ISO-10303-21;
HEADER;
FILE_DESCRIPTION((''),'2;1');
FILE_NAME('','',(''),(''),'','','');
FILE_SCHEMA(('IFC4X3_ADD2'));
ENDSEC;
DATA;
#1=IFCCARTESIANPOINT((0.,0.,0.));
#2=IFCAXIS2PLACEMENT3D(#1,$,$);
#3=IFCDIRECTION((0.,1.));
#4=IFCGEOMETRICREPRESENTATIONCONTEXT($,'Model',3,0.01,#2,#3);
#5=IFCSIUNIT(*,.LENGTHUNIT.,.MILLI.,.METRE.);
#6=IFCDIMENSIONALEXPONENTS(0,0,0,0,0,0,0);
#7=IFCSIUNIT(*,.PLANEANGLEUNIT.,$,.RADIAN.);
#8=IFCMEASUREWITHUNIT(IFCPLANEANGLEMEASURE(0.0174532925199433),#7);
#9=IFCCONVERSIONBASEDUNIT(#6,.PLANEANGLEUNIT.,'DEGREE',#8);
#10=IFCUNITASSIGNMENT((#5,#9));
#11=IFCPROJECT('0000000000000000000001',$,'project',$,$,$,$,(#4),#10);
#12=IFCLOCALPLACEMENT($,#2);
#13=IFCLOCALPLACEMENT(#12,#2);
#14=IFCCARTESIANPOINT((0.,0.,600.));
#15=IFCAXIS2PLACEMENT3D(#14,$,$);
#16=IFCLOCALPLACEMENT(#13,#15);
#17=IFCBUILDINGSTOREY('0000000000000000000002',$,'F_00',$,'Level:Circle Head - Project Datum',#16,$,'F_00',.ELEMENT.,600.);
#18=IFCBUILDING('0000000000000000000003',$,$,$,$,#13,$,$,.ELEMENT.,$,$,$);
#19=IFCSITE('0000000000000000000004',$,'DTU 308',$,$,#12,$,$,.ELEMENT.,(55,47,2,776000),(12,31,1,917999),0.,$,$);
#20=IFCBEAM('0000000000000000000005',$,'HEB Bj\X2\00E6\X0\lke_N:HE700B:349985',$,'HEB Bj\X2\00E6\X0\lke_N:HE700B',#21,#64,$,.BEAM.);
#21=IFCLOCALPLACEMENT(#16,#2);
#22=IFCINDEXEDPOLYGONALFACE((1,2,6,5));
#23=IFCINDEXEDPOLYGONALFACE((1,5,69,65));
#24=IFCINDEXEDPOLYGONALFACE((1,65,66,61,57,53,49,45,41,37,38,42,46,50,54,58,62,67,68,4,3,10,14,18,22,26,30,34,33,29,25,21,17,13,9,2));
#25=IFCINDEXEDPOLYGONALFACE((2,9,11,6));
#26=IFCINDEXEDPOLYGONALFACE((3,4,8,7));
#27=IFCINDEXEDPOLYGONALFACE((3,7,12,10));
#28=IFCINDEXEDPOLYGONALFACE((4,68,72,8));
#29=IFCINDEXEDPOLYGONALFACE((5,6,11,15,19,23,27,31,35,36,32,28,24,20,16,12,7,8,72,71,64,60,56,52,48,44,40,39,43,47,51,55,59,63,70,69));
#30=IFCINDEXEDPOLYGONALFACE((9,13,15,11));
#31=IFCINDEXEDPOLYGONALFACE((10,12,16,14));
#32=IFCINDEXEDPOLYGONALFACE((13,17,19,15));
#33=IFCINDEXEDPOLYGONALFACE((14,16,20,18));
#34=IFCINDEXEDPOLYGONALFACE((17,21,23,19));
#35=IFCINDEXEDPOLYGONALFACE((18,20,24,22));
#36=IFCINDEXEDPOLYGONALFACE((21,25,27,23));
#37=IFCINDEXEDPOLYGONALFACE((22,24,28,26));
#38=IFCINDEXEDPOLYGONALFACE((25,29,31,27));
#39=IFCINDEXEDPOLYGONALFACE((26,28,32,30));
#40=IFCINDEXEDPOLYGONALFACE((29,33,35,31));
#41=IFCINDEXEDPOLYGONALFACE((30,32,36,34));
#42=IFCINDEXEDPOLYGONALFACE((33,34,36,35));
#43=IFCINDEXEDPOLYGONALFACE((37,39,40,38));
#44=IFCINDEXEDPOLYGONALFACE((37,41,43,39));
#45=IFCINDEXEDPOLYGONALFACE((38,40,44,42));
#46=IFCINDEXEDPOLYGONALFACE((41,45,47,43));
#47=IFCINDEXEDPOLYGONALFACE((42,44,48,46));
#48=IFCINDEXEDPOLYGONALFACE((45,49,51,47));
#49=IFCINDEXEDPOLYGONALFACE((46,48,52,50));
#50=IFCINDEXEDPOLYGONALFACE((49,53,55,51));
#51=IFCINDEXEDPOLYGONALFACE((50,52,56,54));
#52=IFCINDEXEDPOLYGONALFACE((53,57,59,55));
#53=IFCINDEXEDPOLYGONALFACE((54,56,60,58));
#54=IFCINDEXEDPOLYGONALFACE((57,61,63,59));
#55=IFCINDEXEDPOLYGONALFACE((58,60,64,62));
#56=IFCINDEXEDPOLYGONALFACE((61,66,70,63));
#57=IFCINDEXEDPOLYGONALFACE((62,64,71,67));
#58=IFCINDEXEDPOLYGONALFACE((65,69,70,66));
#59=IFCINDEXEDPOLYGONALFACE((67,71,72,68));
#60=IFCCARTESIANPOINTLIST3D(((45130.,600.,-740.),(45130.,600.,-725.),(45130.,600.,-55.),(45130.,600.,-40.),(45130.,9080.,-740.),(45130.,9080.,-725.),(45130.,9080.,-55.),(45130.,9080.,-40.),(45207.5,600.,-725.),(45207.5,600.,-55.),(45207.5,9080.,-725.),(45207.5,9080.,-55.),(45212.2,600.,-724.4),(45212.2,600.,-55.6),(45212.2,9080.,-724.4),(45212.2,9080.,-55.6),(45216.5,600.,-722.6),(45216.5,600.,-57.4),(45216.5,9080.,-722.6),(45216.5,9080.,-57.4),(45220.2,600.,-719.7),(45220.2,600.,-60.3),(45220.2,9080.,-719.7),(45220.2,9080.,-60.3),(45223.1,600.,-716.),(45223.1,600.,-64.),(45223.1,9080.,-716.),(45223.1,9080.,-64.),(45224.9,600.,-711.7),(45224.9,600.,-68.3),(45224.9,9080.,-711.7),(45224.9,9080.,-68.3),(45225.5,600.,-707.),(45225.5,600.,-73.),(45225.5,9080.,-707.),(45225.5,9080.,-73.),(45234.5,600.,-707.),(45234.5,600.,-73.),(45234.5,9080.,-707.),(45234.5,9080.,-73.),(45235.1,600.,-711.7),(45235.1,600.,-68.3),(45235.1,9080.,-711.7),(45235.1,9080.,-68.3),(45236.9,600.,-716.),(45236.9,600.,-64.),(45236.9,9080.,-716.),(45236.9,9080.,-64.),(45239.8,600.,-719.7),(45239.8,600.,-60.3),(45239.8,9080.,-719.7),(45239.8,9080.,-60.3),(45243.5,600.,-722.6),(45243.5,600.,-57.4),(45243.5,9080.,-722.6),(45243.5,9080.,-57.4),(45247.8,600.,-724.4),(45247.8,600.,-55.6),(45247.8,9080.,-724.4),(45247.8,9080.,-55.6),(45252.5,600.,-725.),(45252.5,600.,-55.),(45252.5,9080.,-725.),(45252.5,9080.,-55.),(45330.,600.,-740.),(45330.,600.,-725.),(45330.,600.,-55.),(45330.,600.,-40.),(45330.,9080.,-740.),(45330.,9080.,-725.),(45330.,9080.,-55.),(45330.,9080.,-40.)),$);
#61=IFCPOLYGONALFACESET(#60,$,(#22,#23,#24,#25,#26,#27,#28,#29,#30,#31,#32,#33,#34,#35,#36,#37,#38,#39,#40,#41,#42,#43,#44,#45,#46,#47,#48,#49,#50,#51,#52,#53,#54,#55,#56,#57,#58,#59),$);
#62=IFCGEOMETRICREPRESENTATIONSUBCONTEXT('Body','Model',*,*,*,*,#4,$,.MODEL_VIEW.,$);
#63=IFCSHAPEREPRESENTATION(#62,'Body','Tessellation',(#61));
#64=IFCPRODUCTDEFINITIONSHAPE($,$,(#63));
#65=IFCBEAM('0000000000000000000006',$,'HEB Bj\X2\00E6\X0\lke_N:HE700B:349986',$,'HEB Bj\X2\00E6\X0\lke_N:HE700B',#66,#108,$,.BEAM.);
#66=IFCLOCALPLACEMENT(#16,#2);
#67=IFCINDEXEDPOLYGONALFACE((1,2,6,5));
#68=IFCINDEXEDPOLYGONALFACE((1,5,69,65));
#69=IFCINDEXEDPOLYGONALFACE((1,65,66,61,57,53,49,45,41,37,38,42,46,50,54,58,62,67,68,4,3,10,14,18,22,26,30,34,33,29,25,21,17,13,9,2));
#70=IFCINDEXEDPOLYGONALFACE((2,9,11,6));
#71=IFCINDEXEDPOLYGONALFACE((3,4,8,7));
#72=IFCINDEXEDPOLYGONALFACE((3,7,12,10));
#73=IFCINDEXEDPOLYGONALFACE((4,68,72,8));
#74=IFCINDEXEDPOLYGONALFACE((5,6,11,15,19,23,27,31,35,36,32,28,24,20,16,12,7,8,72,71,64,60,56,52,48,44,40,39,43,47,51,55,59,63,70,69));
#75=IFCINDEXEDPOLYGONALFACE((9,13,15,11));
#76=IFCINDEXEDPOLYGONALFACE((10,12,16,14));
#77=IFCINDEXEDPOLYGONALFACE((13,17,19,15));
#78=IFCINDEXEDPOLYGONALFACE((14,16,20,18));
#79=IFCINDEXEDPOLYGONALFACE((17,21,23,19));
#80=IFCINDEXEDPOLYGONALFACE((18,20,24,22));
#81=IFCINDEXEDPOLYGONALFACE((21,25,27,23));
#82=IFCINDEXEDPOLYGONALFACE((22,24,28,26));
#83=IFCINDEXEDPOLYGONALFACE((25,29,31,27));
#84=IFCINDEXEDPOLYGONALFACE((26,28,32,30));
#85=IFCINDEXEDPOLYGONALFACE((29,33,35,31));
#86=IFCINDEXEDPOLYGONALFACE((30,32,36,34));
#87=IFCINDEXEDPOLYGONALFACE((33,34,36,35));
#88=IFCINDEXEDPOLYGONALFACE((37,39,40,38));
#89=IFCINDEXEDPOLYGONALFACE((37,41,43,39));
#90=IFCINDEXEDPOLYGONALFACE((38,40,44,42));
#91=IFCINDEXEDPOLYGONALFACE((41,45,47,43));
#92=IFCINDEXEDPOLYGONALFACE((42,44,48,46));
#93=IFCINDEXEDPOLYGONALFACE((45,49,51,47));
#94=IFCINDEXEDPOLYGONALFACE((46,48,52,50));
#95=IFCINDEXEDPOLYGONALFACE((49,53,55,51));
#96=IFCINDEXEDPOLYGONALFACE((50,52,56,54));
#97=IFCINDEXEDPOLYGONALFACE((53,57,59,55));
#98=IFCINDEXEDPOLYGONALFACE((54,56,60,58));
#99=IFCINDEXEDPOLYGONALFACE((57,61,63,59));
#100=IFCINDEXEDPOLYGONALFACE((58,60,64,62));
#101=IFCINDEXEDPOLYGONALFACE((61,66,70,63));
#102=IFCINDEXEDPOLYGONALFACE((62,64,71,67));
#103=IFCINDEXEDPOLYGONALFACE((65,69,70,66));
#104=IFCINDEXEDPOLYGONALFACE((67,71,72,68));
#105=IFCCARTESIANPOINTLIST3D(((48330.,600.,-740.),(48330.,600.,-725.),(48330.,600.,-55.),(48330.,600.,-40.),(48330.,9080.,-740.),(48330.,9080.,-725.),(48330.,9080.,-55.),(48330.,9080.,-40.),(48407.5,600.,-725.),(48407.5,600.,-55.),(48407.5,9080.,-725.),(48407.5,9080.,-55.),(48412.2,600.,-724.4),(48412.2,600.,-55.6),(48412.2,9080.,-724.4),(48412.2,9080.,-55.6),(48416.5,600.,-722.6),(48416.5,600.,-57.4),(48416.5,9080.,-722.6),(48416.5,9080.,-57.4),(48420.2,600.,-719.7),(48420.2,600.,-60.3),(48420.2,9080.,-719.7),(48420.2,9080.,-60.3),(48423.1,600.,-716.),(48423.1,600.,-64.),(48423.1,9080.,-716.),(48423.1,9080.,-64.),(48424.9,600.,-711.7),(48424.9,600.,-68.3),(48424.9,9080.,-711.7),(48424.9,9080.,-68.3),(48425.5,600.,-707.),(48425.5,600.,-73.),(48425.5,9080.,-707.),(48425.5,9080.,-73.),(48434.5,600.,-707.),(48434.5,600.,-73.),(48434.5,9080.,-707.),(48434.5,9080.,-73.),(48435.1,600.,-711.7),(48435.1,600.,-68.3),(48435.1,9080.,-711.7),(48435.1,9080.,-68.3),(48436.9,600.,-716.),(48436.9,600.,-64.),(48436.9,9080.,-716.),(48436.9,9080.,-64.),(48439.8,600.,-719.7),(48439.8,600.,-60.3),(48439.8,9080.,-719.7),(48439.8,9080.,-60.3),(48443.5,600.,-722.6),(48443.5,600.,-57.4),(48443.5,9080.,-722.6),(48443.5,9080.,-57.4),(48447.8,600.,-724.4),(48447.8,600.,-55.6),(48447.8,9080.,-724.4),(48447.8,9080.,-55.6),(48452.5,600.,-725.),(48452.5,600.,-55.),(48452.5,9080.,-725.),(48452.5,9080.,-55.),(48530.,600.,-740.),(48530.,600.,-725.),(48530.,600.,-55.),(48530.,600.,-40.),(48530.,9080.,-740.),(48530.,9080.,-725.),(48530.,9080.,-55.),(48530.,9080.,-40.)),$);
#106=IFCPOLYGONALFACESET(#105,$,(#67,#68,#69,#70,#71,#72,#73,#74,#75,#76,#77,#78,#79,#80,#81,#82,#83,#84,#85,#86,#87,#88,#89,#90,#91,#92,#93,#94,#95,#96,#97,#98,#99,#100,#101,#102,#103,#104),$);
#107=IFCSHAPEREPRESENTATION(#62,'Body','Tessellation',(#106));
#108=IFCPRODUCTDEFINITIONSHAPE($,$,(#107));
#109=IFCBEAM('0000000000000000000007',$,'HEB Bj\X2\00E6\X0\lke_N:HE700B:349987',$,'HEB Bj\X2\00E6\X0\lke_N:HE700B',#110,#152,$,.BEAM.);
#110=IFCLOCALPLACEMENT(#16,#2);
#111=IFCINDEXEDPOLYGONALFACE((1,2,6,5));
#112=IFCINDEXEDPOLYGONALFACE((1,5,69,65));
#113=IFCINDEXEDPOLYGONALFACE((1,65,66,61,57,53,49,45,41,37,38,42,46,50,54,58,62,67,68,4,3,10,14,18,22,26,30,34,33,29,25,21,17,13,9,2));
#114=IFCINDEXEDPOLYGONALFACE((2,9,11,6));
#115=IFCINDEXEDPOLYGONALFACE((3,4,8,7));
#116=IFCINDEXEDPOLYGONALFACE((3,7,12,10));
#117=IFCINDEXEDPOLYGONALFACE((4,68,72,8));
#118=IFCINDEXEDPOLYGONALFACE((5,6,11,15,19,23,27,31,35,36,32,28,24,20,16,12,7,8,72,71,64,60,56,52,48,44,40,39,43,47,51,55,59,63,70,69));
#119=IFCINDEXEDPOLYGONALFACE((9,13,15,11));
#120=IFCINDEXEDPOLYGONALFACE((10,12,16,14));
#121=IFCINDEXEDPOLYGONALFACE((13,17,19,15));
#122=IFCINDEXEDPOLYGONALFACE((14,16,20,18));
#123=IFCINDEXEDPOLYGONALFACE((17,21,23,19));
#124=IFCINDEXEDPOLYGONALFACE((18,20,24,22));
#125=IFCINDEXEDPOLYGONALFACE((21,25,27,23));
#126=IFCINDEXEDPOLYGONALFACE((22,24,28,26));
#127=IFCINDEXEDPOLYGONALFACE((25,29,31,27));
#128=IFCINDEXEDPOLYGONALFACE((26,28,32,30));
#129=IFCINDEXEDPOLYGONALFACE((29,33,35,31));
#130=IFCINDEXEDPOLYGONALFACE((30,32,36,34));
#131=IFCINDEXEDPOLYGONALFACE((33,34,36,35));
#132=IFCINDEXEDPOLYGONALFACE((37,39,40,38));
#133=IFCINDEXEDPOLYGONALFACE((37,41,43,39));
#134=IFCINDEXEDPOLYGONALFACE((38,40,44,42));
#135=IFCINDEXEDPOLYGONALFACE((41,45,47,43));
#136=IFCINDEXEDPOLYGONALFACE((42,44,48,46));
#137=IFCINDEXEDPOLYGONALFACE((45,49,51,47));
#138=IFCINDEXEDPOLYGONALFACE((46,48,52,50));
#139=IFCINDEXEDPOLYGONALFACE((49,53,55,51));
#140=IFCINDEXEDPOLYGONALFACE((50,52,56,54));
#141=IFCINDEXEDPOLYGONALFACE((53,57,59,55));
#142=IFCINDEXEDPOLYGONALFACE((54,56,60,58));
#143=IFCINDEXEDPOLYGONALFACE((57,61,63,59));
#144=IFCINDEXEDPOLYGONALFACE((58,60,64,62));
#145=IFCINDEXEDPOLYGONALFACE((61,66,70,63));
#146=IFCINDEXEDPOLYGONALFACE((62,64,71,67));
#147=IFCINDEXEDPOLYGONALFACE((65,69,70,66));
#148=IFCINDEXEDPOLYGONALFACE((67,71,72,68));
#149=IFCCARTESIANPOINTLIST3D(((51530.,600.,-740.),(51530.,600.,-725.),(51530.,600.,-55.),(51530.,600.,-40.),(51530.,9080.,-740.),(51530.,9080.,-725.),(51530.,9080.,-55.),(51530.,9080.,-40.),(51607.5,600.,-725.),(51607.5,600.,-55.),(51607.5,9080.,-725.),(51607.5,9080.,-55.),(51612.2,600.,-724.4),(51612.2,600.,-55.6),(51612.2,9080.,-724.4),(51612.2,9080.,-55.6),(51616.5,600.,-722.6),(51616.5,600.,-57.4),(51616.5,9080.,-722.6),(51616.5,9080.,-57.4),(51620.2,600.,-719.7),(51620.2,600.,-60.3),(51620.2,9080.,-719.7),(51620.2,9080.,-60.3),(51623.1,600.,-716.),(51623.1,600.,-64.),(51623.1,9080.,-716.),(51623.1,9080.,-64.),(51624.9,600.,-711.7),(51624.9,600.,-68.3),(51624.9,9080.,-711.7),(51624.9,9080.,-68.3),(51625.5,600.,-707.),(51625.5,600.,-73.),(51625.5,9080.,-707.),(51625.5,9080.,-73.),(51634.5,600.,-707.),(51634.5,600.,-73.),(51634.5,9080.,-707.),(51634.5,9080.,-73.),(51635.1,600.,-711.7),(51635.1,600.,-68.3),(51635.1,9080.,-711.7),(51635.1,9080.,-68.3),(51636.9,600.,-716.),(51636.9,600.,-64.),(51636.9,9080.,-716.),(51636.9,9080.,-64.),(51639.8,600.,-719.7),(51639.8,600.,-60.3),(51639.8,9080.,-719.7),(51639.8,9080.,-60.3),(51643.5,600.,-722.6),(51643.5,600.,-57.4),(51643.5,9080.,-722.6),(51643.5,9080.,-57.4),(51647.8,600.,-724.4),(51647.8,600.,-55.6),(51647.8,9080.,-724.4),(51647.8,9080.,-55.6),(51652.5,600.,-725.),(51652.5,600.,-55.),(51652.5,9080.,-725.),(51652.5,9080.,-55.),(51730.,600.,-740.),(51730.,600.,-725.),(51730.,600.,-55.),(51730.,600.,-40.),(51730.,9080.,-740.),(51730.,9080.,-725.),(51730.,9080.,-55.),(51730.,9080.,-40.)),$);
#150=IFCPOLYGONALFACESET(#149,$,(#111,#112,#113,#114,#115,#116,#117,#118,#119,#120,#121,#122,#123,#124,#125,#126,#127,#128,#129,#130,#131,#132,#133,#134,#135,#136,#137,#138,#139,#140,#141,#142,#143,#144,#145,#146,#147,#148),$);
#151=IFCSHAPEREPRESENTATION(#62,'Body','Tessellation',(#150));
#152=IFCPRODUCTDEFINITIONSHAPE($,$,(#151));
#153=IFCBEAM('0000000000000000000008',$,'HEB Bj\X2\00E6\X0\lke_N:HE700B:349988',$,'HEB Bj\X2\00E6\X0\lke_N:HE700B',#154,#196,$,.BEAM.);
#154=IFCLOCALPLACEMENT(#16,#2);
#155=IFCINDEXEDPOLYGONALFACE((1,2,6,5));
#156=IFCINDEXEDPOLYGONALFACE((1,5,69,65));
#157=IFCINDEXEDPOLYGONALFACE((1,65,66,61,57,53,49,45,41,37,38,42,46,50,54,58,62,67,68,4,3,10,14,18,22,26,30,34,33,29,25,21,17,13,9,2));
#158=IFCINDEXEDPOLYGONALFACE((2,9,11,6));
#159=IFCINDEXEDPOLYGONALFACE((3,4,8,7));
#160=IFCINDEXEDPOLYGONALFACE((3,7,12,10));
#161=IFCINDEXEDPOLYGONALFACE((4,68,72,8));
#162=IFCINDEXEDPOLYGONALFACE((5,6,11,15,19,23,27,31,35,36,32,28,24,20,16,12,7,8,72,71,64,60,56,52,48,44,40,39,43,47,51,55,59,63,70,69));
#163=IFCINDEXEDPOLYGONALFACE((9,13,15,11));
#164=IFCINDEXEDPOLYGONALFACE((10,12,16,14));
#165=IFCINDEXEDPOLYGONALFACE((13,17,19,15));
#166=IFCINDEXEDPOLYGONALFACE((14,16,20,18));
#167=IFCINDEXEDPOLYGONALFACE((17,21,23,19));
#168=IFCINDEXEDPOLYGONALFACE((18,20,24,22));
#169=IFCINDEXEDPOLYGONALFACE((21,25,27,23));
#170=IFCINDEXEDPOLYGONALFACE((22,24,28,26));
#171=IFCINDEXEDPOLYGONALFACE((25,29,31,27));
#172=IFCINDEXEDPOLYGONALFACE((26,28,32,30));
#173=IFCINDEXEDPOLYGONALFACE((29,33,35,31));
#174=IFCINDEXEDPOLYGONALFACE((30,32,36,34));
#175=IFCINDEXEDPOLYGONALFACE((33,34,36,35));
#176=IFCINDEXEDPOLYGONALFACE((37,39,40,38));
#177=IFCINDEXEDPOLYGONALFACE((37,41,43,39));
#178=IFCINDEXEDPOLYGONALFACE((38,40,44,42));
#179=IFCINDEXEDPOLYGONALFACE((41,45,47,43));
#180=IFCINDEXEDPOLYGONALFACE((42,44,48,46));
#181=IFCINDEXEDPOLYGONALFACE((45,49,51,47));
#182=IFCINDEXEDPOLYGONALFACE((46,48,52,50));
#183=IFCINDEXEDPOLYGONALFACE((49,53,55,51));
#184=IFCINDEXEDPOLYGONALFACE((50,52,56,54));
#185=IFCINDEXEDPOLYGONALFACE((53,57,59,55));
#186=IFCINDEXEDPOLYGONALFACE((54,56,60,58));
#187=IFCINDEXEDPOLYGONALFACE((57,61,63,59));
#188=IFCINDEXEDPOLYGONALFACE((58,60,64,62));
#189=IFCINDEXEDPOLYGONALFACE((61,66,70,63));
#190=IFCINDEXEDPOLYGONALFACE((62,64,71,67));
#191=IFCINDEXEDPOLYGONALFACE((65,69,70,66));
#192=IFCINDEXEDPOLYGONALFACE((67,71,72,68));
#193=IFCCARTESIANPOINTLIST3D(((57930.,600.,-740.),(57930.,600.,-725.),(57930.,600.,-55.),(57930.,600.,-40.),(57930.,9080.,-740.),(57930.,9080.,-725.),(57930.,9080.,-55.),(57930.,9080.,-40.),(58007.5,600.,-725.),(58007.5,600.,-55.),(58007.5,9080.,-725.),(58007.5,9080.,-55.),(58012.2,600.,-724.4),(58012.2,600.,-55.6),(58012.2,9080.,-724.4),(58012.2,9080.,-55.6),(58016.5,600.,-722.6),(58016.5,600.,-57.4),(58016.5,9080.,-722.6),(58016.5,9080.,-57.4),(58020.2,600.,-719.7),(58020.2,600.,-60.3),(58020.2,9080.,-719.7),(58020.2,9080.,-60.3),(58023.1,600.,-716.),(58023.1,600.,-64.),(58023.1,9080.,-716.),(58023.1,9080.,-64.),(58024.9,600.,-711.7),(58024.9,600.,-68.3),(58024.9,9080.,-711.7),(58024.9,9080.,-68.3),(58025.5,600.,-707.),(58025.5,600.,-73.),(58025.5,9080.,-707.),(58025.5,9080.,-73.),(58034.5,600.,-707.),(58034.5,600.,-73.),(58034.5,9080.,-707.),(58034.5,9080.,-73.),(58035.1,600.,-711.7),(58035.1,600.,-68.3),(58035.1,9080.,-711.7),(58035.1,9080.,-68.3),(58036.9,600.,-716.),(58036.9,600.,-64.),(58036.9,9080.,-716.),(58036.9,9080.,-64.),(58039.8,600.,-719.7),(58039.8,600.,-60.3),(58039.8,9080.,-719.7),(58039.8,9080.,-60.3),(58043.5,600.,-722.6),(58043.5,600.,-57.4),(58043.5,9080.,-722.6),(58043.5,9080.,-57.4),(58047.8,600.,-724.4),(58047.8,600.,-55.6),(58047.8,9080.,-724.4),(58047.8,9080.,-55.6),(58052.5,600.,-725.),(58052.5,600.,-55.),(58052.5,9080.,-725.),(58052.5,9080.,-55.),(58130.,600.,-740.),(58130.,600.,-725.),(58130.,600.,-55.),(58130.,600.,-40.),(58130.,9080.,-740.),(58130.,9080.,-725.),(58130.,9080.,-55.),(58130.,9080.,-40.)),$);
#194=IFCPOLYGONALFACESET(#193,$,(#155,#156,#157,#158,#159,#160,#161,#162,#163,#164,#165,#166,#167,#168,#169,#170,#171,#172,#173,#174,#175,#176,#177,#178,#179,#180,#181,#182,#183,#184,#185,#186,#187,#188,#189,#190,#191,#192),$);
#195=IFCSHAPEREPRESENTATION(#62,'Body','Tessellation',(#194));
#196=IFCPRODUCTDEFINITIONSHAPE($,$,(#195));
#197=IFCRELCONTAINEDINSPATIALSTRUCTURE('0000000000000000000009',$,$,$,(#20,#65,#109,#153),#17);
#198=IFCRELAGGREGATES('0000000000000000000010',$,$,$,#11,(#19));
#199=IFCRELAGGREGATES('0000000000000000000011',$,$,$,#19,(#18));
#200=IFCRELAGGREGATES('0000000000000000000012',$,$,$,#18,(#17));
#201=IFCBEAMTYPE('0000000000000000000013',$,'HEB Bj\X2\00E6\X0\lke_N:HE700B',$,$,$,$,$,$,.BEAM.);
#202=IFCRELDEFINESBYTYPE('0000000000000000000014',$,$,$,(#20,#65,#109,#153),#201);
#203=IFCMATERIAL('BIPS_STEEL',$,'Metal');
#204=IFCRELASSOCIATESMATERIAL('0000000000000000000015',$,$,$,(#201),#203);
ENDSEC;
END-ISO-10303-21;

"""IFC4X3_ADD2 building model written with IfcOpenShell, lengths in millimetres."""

from ifc_helpers import new_model, entity, si_unit, converted_unit, direction, frame, frame_2d, origin, place, context, subcontext, project, spatial, i_section, extrude, source, transform, mapped, material, material_profile, profile_set, type_object, element, save


model = new_model("IFC4X3_ADD2")

# Units and contexts
model_context = context("Model", 3, precision=0.01, world=origin(), true_north=direction((0.0, 1.0)))
body_context = subcontext(model_context, "Body", "Model", "MODEL_VIEW")
ifc_project = project(units=[si_unit("LENGTHUNIT", "METRE", prefix="MILLI"), converted_unit("PLANEANGLEUNIT", "DEGREE", entity("IfcPlaneAngleMeasure", 0.0174532925199433), si_unit("PLANEANGLEUNIT", "RADIAN"), dimensions=[0, 0, 0, 0, 0, 0, 0])], contexts=[model_context])

# Site, building, storey
site_placement = place(None, origin())
site = spatial("IfcSite", under=ifc_project, at=site_placement, Name="DTU 308", CompositionType="ELEMENT", RefLatitude=(55, 47, 2, 776000), RefLongitude=(12, 31, 1, 917999), RefElevation=0.0)
building_placement = place(site_placement, origin())
building = spatial("IfcBuilding", under=site, at=building_placement, CompositionType="ELEMENT")
storey_placement = place(building_placement, frame((0.0, 0.0, 600.0)))
storey = spatial("IfcBuildingStorey", under=building, at=storey_placement, Name="F_00", ObjectType="Level:Circle Head - Project Datum", LongName="F_00", CompositionType="ELEMENT", Elevation=600.0)

# Beams
ifc_material_1 = material(Name="BIPS_STEEL", Category="Metal")
ifc_material_profile_1 = material_profile(ifc_material_1, i_section(OverallWidth=200.0, OverallDepth=700.0, WebThickness=9.0, FlangeThickness=15.0, FilletRadius=18.0, at=frame_2d((0.0, 0.0), x_axis=(1.0, 0.0))), Name="HE700B")
ifc_profile_set_1 = profile_set([ifc_material_profile_1], Name="HE700B")
beam_type = type_object("IfcBeamType", Name="HEB Bjælke_N:HE700B", PredefinedType="BEAM", material=ifc_profile_set_1)
shared_shape_1 = source(origin(), body_context, "Body", "SweptSolid", [
    extrude(i_section(OverallWidth=200.0, OverallDepth=700.0, WebThickness=9.0, FlangeThickness=15.0, FilletRadius=18.0, at=frame_2d((0.0, 0.0), x_axis=(1.0, 0.0))), frame((45230.0, 9080.0, 210.0), z_axis=(0.0, -1.0, 0.0), x_axis=(-1.0, 0.0, 0.0)), (0.0, 0.0, 1.0), 8480.0),
])
beam_1_placement = place(storey_placement, frame((0.0, 0.0, -600.0)))
element("IfcBeam", 1, at=beam_1_placement, inside=storey, type_object=beam_type, Name="HEB Bjælke_N:HE700B:349985", ObjectType="HEB Bjælke_N:HE700B", PredefinedType="BEAM", context=body_context, shape_type="MappedRepresentation", body=[
    mapped(shared_shape_1, transform((0.0, 0.0, 0.0), scale=1.0)),
])
shared_shape_2 = source(origin(), body_context, "Body", "SweptSolid", [
    extrude(i_section(OverallWidth=200.0, OverallDepth=700.0, WebThickness=9.0, FlangeThickness=15.0, FilletRadius=18.0, at=frame_2d((0.0, 0.0), x_axis=(1.0, 0.0))), frame((48430.0, 9080.0, 210.0), z_axis=(0.0, -1.0, 0.0), x_axis=(-1.0, 0.0, 0.0)), (0.0, 0.0, 1.0), 8480.0),
])
beam_2_placement = place(storey_placement, frame((0.0, 0.0, -600.0)))
element("IfcBeam", 2, at=beam_2_placement, inside=storey, type_object=beam_type, Name="HEB Bjælke_N:HE700B:349986", ObjectType="HEB Bjælke_N:HE700B", PredefinedType="BEAM", context=body_context, shape_type="MappedRepresentation", body=[
    mapped(shared_shape_2, transform((0.0, 0.0, 0.0), scale=1.0)),
])
shared_shape_3 = source(origin(), body_context, "Body", "SweptSolid", [
    extrude(i_section(OverallWidth=200.0, OverallDepth=700.0, WebThickness=9.0, FlangeThickness=15.0, FilletRadius=18.0, at=frame_2d((0.0, 0.0), x_axis=(1.0, 0.0))), frame((51630.0, 9080.0, 210.0), z_axis=(0.0, -1.0, 0.0), x_axis=(-1.0, 0.0, 0.0)), (0.0, 0.0, 1.0), 8480.0),
])
beam_3_placement = place(storey_placement, frame((0.0, 0.0, -600.0)))
element("IfcBeam", 3, at=beam_3_placement, inside=storey, type_object=beam_type, Name="HEB Bjælke_N:HE700B:349987", ObjectType="HEB Bjælke_N:HE700B", PredefinedType="BEAM", context=body_context, shape_type="MappedRepresentation", body=[
    mapped(shared_shape_3, transform((0.0, 0.0, 0.0), scale=1.0)),
])
shared_shape_4 = source(origin(), body_context, "Body", "SweptSolid", [
    extrude(i_section(OverallWidth=200.0, OverallDepth=700.0, WebThickness=9.0, FlangeThickness=15.0, FilletRadius=18.0, at=frame_2d((0.0, 0.0), x_axis=(1.0, 0.0))), frame((58030.0, 9080.0, 210.0), z_axis=(0.0, -1.0, 0.0), x_axis=(-1.0, 0.0, 0.0)), (0.0, 0.0, 1.0), 8480.0),
])
beam_4_placement = place(storey_placement, frame((0.0, 0.0, -600.0)))
element("IfcBeam", 4, at=beam_4_placement, inside=storey, type_object=beam_type, Name="HEB Bjælke_N:HE700B:349988", ObjectType="HEB Bjælke_N:HE700B", PredefinedType="BEAM", context=body_context, shape_type="MappedRepresentation", body=[
    mapped(shared_shape_4, transform((0.0, 0.0, 0.0), scale=1.0)),
])

save(model, "model.ifc")
